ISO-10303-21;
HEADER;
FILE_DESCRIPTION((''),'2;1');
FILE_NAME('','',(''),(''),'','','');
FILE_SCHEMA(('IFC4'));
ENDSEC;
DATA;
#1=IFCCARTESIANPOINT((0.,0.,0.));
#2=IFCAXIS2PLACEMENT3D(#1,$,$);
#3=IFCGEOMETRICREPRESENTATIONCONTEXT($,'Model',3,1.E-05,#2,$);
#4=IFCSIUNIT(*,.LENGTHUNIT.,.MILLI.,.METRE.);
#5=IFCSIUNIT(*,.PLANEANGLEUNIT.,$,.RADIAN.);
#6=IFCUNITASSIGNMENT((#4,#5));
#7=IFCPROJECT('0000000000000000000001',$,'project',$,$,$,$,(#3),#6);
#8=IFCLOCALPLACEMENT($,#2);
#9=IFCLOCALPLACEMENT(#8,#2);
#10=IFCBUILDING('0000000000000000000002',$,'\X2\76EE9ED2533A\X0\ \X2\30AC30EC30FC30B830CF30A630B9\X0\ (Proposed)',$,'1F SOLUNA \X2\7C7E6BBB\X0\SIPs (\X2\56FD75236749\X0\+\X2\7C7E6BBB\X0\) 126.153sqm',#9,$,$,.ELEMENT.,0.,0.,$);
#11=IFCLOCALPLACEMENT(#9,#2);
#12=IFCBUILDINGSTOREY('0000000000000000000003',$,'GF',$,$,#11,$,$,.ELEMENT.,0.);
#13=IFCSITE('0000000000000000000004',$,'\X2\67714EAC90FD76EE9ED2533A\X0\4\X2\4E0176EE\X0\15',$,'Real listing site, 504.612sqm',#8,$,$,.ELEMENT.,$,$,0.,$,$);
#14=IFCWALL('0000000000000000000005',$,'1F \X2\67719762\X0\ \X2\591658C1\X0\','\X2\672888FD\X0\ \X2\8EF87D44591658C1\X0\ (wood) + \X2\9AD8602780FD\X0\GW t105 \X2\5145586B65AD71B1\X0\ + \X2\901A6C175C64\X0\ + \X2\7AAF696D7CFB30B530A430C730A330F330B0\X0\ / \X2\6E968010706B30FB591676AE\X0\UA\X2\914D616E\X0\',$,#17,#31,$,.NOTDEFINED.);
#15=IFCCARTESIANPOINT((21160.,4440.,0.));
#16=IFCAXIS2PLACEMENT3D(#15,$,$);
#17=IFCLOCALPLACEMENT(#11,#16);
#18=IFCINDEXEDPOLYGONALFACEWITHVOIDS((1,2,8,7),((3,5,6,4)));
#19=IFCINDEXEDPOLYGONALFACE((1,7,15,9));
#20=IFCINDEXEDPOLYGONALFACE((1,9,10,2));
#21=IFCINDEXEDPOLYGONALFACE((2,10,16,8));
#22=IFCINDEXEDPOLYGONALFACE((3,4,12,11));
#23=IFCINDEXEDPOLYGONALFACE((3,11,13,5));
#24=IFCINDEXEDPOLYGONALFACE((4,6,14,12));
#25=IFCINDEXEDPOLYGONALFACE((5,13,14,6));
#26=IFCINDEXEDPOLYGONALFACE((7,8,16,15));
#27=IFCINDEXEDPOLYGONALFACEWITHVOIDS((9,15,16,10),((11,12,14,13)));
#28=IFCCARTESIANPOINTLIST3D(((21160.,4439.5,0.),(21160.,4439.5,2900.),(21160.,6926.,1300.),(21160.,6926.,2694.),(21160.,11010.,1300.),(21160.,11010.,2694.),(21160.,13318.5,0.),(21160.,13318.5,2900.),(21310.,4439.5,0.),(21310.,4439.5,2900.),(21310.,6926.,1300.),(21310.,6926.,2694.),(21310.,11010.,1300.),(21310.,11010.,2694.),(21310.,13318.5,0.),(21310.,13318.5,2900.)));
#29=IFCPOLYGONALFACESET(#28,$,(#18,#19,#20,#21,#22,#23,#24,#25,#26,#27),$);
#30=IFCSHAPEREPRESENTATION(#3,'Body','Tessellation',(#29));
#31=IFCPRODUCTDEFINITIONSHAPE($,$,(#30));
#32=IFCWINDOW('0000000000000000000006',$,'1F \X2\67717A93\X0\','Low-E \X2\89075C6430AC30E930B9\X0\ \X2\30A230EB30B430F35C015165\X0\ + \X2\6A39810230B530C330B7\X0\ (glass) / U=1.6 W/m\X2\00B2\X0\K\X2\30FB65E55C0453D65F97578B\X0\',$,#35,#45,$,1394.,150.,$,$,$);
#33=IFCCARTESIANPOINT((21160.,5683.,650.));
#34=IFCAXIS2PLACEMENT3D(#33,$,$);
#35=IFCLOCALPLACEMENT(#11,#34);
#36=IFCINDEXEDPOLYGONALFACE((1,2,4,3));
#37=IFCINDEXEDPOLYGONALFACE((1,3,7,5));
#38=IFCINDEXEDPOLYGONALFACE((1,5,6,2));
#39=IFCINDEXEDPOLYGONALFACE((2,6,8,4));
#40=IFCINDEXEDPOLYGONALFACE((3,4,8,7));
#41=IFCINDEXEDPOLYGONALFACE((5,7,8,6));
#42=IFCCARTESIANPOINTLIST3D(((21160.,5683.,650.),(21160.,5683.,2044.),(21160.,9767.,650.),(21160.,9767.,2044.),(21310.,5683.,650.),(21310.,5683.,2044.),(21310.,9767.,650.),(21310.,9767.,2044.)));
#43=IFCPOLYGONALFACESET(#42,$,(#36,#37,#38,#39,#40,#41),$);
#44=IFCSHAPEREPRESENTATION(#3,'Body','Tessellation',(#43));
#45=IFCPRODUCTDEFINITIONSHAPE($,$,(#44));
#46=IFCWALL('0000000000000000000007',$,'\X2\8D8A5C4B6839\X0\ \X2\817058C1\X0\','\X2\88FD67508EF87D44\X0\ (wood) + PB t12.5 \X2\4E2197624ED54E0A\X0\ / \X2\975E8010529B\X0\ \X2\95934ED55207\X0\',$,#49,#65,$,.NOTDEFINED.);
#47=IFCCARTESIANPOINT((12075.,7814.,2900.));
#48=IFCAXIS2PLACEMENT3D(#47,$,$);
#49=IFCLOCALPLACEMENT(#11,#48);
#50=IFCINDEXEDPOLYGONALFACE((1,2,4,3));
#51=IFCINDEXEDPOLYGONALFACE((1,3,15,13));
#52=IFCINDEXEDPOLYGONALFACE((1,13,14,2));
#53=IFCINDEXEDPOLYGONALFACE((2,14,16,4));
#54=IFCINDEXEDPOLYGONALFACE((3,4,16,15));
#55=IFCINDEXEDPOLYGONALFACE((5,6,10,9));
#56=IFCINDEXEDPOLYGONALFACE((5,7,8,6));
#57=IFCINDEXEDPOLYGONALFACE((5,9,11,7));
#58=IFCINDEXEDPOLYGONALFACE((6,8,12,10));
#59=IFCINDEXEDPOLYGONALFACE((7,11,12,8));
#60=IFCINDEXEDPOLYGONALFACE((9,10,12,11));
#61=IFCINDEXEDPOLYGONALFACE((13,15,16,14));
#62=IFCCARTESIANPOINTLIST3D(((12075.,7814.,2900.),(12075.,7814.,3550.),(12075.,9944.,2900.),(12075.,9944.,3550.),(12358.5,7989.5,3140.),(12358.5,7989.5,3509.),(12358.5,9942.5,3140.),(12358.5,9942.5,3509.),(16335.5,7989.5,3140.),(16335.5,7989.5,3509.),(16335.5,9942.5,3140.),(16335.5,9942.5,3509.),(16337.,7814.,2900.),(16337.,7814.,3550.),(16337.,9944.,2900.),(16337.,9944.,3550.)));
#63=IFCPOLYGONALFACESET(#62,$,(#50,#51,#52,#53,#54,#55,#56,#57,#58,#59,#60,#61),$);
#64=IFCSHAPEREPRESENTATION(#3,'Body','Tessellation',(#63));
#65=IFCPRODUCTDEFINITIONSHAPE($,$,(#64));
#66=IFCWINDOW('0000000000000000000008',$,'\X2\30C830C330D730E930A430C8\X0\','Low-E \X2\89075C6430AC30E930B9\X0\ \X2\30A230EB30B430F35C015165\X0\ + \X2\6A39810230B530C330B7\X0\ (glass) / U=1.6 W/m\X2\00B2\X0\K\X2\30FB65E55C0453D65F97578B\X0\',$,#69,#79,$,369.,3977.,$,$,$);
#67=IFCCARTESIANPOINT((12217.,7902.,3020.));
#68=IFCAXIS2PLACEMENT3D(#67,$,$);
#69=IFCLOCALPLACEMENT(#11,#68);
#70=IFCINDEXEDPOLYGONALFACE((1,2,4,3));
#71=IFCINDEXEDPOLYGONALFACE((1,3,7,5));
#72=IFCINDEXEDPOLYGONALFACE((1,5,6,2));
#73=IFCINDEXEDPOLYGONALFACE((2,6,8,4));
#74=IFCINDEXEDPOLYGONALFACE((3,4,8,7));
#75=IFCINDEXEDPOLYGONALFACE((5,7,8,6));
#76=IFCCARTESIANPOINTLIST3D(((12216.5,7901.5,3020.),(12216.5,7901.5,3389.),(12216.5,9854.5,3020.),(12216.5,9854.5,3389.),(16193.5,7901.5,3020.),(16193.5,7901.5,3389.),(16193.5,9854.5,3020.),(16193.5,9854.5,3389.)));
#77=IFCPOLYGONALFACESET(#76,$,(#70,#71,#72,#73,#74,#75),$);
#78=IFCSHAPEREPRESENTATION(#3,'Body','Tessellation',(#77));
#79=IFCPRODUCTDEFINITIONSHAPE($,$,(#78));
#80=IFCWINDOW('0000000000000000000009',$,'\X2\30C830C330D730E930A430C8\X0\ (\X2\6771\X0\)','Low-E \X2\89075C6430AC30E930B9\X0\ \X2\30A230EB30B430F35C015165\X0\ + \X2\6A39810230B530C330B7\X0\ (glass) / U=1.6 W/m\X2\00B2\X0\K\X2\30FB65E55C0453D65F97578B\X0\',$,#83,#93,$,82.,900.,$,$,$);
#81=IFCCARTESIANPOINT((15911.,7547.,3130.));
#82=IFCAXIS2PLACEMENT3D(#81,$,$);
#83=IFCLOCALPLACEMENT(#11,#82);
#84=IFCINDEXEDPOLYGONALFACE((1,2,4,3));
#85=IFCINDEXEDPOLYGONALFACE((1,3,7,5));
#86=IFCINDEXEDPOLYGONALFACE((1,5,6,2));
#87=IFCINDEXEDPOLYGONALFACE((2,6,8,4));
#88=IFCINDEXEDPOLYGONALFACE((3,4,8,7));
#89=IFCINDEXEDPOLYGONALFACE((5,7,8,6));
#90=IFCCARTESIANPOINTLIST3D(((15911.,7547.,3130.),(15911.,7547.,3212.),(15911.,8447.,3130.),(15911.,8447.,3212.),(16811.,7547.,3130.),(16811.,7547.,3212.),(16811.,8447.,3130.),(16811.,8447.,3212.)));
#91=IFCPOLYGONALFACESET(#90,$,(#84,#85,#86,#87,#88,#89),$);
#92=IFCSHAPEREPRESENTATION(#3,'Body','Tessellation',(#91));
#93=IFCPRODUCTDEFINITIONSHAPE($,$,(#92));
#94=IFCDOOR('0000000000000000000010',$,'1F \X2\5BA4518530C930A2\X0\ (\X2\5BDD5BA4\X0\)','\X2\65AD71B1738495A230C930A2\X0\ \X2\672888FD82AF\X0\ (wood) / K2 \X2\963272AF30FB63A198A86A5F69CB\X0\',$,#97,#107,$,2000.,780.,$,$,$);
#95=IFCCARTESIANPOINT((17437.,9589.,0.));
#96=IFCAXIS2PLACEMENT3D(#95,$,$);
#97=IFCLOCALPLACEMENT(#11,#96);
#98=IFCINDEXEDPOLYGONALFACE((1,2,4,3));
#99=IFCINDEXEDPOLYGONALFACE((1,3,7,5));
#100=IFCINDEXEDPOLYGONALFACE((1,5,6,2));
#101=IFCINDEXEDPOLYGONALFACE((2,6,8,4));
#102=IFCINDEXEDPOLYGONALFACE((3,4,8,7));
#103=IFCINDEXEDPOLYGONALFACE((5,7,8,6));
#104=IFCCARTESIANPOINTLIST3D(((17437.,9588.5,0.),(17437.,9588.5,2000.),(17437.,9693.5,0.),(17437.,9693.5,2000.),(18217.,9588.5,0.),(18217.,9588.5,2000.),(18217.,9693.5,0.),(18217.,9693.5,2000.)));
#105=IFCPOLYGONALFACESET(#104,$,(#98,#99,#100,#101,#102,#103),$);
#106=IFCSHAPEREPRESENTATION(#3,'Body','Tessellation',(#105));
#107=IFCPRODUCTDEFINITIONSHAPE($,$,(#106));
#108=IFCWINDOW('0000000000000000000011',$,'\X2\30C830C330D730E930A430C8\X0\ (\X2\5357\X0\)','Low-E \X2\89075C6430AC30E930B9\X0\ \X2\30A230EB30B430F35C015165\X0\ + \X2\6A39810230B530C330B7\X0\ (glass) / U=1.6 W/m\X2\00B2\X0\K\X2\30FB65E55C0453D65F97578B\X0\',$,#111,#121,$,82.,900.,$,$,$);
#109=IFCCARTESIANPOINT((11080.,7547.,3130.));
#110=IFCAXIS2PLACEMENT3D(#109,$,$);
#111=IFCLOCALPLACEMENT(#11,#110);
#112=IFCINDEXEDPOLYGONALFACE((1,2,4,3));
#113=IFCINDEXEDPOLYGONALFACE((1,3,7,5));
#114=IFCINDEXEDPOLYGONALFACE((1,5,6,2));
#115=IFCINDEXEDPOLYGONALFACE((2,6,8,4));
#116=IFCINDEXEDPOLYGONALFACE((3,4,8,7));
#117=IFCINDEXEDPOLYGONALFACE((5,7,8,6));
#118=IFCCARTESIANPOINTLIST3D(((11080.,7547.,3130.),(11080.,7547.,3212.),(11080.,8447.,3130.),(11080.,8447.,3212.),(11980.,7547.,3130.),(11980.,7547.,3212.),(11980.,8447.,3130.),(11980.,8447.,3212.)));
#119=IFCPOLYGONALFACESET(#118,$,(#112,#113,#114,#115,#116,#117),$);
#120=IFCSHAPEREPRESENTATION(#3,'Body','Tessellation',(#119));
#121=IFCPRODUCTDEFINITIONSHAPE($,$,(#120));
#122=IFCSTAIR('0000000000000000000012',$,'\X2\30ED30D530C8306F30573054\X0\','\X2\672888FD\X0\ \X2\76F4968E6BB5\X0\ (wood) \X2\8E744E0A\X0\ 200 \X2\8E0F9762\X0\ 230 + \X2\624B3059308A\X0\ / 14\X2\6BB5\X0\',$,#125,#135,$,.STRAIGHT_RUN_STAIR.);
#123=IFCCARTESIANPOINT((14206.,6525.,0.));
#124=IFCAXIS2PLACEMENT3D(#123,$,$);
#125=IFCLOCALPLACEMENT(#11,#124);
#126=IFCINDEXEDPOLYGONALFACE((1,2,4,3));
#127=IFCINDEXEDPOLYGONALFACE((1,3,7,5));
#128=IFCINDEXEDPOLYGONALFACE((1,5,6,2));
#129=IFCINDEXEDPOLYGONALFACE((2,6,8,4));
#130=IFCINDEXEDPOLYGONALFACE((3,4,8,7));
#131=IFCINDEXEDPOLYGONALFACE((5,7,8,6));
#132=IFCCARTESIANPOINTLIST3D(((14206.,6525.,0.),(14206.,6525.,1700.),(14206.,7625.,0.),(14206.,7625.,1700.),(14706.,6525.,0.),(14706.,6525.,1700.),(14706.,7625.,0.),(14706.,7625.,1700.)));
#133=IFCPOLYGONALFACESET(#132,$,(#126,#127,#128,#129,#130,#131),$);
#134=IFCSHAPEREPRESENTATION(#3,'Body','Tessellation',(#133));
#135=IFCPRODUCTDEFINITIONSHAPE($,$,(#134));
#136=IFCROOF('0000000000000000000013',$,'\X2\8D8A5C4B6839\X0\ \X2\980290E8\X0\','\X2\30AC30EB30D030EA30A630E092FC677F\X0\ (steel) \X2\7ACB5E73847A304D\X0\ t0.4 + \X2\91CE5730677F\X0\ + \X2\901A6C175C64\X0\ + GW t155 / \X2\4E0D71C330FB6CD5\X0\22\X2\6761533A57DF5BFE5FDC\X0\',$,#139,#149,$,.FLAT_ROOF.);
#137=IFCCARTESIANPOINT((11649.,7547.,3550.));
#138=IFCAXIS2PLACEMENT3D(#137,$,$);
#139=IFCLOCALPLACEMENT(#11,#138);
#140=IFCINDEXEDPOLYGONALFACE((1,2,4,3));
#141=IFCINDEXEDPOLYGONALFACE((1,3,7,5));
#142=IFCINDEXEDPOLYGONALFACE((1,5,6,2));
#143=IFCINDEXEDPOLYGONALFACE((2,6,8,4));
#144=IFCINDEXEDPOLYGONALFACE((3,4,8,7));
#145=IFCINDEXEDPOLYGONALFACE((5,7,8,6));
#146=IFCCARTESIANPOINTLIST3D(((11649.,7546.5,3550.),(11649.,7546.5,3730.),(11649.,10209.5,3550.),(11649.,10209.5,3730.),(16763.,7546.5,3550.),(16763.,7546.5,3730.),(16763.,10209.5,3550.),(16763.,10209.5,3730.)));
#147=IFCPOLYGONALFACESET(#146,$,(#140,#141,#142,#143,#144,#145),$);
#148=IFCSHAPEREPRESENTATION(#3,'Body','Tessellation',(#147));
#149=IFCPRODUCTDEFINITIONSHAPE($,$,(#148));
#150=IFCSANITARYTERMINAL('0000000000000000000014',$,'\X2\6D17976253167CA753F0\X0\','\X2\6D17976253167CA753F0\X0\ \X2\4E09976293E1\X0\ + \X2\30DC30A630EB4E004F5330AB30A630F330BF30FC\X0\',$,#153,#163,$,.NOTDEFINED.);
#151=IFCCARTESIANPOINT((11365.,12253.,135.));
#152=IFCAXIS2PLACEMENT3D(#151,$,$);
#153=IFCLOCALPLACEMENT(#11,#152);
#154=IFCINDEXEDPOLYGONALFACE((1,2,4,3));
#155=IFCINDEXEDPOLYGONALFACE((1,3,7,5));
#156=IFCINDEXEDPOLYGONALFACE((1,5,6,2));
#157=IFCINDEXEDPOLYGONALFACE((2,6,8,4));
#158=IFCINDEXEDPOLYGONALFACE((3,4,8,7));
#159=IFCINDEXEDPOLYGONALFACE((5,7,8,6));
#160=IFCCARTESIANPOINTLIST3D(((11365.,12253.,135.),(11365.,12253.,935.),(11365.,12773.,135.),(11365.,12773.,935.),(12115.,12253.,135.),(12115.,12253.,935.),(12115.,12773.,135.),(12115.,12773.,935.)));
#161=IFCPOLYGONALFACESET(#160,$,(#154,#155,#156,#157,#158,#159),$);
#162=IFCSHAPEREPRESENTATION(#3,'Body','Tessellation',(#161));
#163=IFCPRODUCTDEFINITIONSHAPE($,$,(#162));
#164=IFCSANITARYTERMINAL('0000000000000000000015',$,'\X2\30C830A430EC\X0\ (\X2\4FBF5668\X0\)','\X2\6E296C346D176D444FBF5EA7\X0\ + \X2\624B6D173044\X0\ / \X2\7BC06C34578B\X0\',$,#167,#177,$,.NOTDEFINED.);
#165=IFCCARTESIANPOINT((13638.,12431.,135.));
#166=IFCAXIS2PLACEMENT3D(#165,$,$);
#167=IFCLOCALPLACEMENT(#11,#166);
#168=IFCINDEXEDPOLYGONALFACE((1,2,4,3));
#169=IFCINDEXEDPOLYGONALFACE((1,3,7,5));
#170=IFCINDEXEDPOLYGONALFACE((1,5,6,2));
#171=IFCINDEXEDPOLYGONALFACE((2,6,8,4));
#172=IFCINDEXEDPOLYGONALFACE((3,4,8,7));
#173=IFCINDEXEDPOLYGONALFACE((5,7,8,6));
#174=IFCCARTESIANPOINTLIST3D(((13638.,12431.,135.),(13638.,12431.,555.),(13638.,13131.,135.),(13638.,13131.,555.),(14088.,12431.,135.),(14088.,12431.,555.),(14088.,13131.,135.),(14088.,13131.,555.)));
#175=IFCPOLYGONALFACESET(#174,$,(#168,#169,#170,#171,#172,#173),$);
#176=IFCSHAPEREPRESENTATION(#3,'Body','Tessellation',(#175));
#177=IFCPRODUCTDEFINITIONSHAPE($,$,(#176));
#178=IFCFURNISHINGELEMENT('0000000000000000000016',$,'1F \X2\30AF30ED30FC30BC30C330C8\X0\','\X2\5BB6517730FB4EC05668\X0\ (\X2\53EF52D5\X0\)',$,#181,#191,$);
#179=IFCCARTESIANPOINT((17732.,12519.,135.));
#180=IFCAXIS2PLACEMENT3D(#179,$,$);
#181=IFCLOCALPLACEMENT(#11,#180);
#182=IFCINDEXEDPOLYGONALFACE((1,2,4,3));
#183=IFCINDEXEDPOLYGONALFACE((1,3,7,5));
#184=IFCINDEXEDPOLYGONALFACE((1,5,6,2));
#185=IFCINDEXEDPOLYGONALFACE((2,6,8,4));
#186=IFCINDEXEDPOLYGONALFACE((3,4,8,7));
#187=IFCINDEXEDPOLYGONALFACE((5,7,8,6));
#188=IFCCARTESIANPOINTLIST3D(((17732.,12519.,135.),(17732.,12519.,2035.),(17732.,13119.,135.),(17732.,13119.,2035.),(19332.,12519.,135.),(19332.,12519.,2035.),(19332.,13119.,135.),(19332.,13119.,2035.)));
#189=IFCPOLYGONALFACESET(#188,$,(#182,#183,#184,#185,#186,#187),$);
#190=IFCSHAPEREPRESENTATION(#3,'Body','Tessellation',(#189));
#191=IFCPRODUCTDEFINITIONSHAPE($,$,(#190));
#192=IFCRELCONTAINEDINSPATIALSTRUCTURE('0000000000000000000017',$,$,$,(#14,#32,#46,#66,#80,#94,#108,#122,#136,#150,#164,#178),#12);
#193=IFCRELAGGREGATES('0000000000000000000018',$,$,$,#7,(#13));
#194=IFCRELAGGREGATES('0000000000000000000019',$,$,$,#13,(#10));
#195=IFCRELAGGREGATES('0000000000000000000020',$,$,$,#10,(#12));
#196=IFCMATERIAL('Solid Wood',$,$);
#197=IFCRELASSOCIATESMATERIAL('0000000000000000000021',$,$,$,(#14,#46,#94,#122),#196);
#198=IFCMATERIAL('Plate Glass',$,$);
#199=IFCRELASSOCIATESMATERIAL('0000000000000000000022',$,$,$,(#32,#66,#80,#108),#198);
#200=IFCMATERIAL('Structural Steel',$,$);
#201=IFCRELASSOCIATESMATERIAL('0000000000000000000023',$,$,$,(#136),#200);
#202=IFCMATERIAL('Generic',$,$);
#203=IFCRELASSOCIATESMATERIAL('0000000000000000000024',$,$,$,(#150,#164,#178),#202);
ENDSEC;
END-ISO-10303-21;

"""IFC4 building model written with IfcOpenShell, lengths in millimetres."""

from ifc_helpers import new_model, si_unit, frame, frame_2d, origin, place, context, project, spatial, rectangle, extrude, material, element, fill, save


model = new_model("IFC4")

# Units and contexts
model_context = context("Model", 3, precision=1e-05, world=origin())
ifc_project = project(units=[si_unit("LENGTHUNIT", "METRE", prefix="MILLI"), si_unit("PLANEANGLEUNIT", "RADIAN")], contexts=[model_context])

# Site, building, storey
site_placement = place(None, origin())
site = spatial("IfcSite", under=ifc_project, at=site_placement, Name="東京都目黒区4丁目15", ObjectType="Real listing site, 504.612sqm", CompositionType="ELEMENT", RefElevation=0.0)
building_placement = place(site_placement, origin())
building = spatial("IfcBuilding", under=site, at=building_placement, Name="目黒区 ガレージハウス (Proposed)", ObjectType="1F SOLUNA 籾殻SIPs (国産杉+籾殻) 126.153sqm", CompositionType="ELEMENT", ElevationOfRefHeight=0.0, ElevationOfTerrain=0.0)
storey_placement = place(building_placement, origin())
storey = spatial("IfcBuildingStorey", under=building, at=storey_placement, Name="GF", CompositionType="ELEMENT", Elevation=0.0)

# Wall, opening, window
ifc_material_1 = material(Name="Solid Wood")
wall_1_placement = place(storey_placement, frame((21160.0, 4440.0, 0.0)))
wall_1 = element("IfcWall", 1, at=wall_1_placement, inside=storey, material=ifc_material_1, Name="1F 東面 外壁", Description="木製 軸組外壁 (wood) + 高性能GW t105 充填断熱 + 通気層 + 窯業系サイディング / 準耐火・外皮UA配慮", PredefinedType="NOTDEFINED", context=model_context, shape_type="SweptSolid", body=[
    extrude(rectangle(XDim=150.0, YDim=8879.0, at=frame_2d((75.0, 4439.0))), frame((21160.0, 4440.0, 0.0)), (0.0, 0.0, 1.0), 2900.0),
])
opening_1_placement = place(storey_placement, frame((21160.0, 5683.0, 650.0)))
opening_1 = element("IfcOpeningElement", 2, at=opening_1_placement, cuts=wall_1, PredefinedType="NOTDEFINED", context=model_context, shape_type="SweptSolid", body=[
    extrude(rectangle(XDim=150.0, YDim=4084.0, at=frame_2d((75.0, 2042.0))), frame((21160.0, 5683.0, 650.0)), (0.0, 0.0, 1.0), 1394.0),
])
ifc_material_2 = material(Name="Plate Glass")
window_1_placement = place(storey_placement, frame((21160.0, 5683.0, 650.0)))
window_1 = element("IfcWindow", 3, at=window_1_placement, inside=storey, material=ifc_material_2, Name="1F 東窓", Description="Low-E 複層ガラス アルゴン封入 + 樹脂サッシ (glass) / U=1.6 W/m²K・日射取得型", OverallHeight=1394.0, OverallWidth=150.0, context=model_context, shape_type="SweptSolid", body=[
    extrude(rectangle(XDim=150.0, YDim=4084.0, at=frame_2d((75.0, 2042.0))), frame((21160.0, 5683.0, 650.0)), (0.0, 0.0, 1.0), 1394.0),
])
fill(opening_1, window_1)

# Wall, openings, windows
wall_2_placement = place(storey_placement, frame((12075.0, 7814.0, 2900.0)))
wall_2 = element("IfcWall", 4, at=wall_2_placement, inside=storey, material=ifc_material_1, Name="越屋根 腰壁", Description="製材軸組 (wood) + PB t12.5 両面仕上 / 非耐力 間仕切", PredefinedType="NOTDEFINED", context=model_context, shape_type="SweptSolid", body=[
    extrude(rectangle(XDim=4262.0, YDim=2130.0, at=frame_2d((2131.0, 1065.0))), frame((12075.0, 7814.0, 2900.0)), (0.0, 0.0, 1.0), 650.0),
])
opening_2_placement = place(storey_placement, frame((12217.0, 7902.0, 3020.0)))
opening_2 = element("IfcOpeningElement", 5, at=opening_2_placement, cuts=wall_2, PredefinedType="NOTDEFINED", context=model_context, shape_type="SweptSolid", body=[
    extrude(rectangle(XDim=3977.0, YDim=1953.0, at=frame_2d((1988.0, 976.0))), frame((12217.0, 7902.0, 3020.0)), (0.0, 0.0, 1.0), 369.0),
])
opening_3_placement = place(storey_placement, frame((15911.0, 7547.0, 3130.0)))
opening_3 = element("IfcOpeningElement", 6, at=opening_3_placement, cuts=wall_2, PredefinedType="NOTDEFINED", context=model_context, shape_type="SweptSolid", body=[
    extrude(rectangle(XDim=900.0, YDim=900.0, at=frame_2d((450.0, 450.0))), frame((15911.0, 7547.0, 3130.0)), (0.0, 0.0, 1.0), 82.0),
])
window_2_placement = place(storey_placement, frame((12217.0, 7902.0, 3020.0)))
window_2 = element("IfcWindow", 7, at=window_2_placement, inside=storey, material=ifc_material_2, Name="トップライト", Description="Low-E 複層ガラス アルゴン封入 + 樹脂サッシ (glass) / U=1.6 W/m²K・日射取得型", OverallHeight=369.0, OverallWidth=3977.0, context=model_context, shape_type="SweptSolid", body=[
    extrude(rectangle(XDim=3977.0, YDim=1953.0, at=frame_2d((1988.0, 976.0))), frame((12217.0, 7902.0, 3020.0)), (0.0, 0.0, 1.0), 369.0),
])
fill(opening_2, window_2)
window_3_placement = place(storey_placement, frame((15911.0, 7547.0, 3130.0)))
window_3 = element("IfcWindow", 8, at=window_3_placement, inside=storey, material=ifc_material_2, Name="トップライト (東)", Description="Low-E 複層ガラス アルゴン封入 + 樹脂サッシ (glass) / U=1.6 W/m²K・日射取得型", OverallHeight=82.0, OverallWidth=900.0, context=model_context, shape_type="SweptSolid", body=[
    extrude(rectangle(XDim=900.0, YDim=900.0, at=frame_2d((450.0, 450.0))), frame((15911.0, 7547.0, 3130.0)), (0.0, 0.0, 1.0), 82.0),
])
fill(opening_3, window_3)

# Door
door_placement = place(storey_placement, frame((17437.0, 9589.0, 0.0)))
element("IfcDoor", 9, at=door_placement, inside=storey, material=ifc_material_1, Name="1F 室内ドア (寝室)", Description="断熱玄関ドア 木製芯 (wood) / K2 防犯・採風機構", OverallHeight=2000.0, OverallWidth=780.0, context=model_context, shape_type="SweptSolid", body=[
    extrude(rectangle(XDim=780.0, YDim=105.0, at=frame_2d((390.0, 52.0))), frame((17437.0, 9589.0, 0.0)), (0.0, 0.0, 1.0), 2000.0),
])

# Window
window_4_placement = place(storey_placement, frame((11080.0, 7547.0, 3130.0)))
element("IfcWindow", 10, at=window_4_placement, inside=storey, material=ifc_material_2, Name="トップライト (南)", Description="Low-E 複層ガラス アルゴン封入 + 樹脂サッシ (glass) / U=1.6 W/m²K・日射取得型", OverallHeight=82.0, OverallWidth=900.0, context=model_context, shape_type="SweptSolid", body=[
    extrude(rectangle(XDim=900.0, YDim=900.0, at=frame_2d((450.0, 450.0))), frame((11080.0, 7547.0, 3130.0)), (0.0, 0.0, 1.0), 82.0),
])

# Stair
stair_placement = place(storey_placement, frame((14206.0, 6525.0, 0.0)))
element("IfcStair", 11, at=stair_placement, inside=storey, material=ifc_material_1, Name="ロフトはしご", Description="木製 直階段 (wood) 蹴上 200 踏面 230 + 手すり / 14段", PredefinedType="STRAIGHT_RUN_STAIR", context=model_context, shape_type="SweptSolid", body=[
    extrude(rectangle(XDim=500.0, YDim=1100.0, at=frame_2d((250.0, 550.0))), frame((14206.0, 6525.0, 0.0)), (0.0, 0.0, 1.0), 1700.0),
])

# Roof
ifc_material_3 = material(Name="Structural Steel")
roof_placement = place(storey_placement, frame((11649.0, 7547.0, 3550.0)))
element("IfcRoof", 12, at=roof_placement, inside=storey, material=ifc_material_3, Name="越屋根 頂部", Description="ガルバリウム鋼板 (steel) 立平葺き t0.4 + 野地板 + 通気層 + GW t155 / 不燃・法22条区域対応", PredefinedType="FLAT_ROOF", context=model_context, shape_type="SweptSolid", body=[
    extrude(rectangle(XDim=5114.0, YDim=2663.0, at=frame_2d((2557.0, 1331.0))), frame((11649.0, 7547.0, 3550.0)), (0.0, 0.0, 1.0), 180.0),
])

# Sanitary terminals
ifc_material_4 = material(Name="Generic")
sanitary_terminal_1_placement = place(storey_placement, frame((11365.0, 12253.0, 135.0)))
element("IfcSanitaryTerminal", 13, at=sanitary_terminal_1_placement, inside=storey, material=ifc_material_4, Name="洗面化粧台", Description="洗面化粧台 三面鏡 + ボウル一体カウンター", PredefinedType="NOTDEFINED", context=model_context, shape_type="SweptSolid", body=[
    extrude(rectangle(XDim=750.0, YDim=520.0, at=frame_2d((375.0, 260.0))), frame((11365.0, 12253.0, 135.0)), (0.0, 0.0, 1.0), 800.0),
])
sanitary_terminal_2_placement = place(storey_placement, frame((13638.0, 12431.0, 135.0)))
element("IfcSanitaryTerminal", 14, at=sanitary_terminal_2_placement, inside=storey, material=ifc_material_4, Name="トイレ (便器)", Description="温水洗浄便座 + 手洗い / 節水型", PredefinedType="NOTDEFINED", context=model_context, shape_type="SweptSolid", body=[
    extrude(rectangle(XDim=450.0, YDim=700.0, at=frame_2d((225.0, 350.0))), frame((13638.0, 12431.0, 135.0)), (0.0, 0.0, 1.0), 420.0),
])

# Furnishing element
furnishing_1_placement = place(storey_placement, frame((17732.0, 12519.0, 135.0)))
element("IfcFurnishingElement", 15, at=furnishing_1_placement, inside=storey, material=ifc_material_4, Name="1F クローゼット", Description="家具・什器 (可動)", context=model_context, shape_type="SweptSolid", body=[
    extrude(rectangle(XDim=1600.0, YDim=600.0, at=frame_2d((800.0, 300.0))), frame((17732.0, 12519.0, 135.0)), (0.0, 0.0, 1.0), 1900.0),
])

save(model, "model.ifc")
